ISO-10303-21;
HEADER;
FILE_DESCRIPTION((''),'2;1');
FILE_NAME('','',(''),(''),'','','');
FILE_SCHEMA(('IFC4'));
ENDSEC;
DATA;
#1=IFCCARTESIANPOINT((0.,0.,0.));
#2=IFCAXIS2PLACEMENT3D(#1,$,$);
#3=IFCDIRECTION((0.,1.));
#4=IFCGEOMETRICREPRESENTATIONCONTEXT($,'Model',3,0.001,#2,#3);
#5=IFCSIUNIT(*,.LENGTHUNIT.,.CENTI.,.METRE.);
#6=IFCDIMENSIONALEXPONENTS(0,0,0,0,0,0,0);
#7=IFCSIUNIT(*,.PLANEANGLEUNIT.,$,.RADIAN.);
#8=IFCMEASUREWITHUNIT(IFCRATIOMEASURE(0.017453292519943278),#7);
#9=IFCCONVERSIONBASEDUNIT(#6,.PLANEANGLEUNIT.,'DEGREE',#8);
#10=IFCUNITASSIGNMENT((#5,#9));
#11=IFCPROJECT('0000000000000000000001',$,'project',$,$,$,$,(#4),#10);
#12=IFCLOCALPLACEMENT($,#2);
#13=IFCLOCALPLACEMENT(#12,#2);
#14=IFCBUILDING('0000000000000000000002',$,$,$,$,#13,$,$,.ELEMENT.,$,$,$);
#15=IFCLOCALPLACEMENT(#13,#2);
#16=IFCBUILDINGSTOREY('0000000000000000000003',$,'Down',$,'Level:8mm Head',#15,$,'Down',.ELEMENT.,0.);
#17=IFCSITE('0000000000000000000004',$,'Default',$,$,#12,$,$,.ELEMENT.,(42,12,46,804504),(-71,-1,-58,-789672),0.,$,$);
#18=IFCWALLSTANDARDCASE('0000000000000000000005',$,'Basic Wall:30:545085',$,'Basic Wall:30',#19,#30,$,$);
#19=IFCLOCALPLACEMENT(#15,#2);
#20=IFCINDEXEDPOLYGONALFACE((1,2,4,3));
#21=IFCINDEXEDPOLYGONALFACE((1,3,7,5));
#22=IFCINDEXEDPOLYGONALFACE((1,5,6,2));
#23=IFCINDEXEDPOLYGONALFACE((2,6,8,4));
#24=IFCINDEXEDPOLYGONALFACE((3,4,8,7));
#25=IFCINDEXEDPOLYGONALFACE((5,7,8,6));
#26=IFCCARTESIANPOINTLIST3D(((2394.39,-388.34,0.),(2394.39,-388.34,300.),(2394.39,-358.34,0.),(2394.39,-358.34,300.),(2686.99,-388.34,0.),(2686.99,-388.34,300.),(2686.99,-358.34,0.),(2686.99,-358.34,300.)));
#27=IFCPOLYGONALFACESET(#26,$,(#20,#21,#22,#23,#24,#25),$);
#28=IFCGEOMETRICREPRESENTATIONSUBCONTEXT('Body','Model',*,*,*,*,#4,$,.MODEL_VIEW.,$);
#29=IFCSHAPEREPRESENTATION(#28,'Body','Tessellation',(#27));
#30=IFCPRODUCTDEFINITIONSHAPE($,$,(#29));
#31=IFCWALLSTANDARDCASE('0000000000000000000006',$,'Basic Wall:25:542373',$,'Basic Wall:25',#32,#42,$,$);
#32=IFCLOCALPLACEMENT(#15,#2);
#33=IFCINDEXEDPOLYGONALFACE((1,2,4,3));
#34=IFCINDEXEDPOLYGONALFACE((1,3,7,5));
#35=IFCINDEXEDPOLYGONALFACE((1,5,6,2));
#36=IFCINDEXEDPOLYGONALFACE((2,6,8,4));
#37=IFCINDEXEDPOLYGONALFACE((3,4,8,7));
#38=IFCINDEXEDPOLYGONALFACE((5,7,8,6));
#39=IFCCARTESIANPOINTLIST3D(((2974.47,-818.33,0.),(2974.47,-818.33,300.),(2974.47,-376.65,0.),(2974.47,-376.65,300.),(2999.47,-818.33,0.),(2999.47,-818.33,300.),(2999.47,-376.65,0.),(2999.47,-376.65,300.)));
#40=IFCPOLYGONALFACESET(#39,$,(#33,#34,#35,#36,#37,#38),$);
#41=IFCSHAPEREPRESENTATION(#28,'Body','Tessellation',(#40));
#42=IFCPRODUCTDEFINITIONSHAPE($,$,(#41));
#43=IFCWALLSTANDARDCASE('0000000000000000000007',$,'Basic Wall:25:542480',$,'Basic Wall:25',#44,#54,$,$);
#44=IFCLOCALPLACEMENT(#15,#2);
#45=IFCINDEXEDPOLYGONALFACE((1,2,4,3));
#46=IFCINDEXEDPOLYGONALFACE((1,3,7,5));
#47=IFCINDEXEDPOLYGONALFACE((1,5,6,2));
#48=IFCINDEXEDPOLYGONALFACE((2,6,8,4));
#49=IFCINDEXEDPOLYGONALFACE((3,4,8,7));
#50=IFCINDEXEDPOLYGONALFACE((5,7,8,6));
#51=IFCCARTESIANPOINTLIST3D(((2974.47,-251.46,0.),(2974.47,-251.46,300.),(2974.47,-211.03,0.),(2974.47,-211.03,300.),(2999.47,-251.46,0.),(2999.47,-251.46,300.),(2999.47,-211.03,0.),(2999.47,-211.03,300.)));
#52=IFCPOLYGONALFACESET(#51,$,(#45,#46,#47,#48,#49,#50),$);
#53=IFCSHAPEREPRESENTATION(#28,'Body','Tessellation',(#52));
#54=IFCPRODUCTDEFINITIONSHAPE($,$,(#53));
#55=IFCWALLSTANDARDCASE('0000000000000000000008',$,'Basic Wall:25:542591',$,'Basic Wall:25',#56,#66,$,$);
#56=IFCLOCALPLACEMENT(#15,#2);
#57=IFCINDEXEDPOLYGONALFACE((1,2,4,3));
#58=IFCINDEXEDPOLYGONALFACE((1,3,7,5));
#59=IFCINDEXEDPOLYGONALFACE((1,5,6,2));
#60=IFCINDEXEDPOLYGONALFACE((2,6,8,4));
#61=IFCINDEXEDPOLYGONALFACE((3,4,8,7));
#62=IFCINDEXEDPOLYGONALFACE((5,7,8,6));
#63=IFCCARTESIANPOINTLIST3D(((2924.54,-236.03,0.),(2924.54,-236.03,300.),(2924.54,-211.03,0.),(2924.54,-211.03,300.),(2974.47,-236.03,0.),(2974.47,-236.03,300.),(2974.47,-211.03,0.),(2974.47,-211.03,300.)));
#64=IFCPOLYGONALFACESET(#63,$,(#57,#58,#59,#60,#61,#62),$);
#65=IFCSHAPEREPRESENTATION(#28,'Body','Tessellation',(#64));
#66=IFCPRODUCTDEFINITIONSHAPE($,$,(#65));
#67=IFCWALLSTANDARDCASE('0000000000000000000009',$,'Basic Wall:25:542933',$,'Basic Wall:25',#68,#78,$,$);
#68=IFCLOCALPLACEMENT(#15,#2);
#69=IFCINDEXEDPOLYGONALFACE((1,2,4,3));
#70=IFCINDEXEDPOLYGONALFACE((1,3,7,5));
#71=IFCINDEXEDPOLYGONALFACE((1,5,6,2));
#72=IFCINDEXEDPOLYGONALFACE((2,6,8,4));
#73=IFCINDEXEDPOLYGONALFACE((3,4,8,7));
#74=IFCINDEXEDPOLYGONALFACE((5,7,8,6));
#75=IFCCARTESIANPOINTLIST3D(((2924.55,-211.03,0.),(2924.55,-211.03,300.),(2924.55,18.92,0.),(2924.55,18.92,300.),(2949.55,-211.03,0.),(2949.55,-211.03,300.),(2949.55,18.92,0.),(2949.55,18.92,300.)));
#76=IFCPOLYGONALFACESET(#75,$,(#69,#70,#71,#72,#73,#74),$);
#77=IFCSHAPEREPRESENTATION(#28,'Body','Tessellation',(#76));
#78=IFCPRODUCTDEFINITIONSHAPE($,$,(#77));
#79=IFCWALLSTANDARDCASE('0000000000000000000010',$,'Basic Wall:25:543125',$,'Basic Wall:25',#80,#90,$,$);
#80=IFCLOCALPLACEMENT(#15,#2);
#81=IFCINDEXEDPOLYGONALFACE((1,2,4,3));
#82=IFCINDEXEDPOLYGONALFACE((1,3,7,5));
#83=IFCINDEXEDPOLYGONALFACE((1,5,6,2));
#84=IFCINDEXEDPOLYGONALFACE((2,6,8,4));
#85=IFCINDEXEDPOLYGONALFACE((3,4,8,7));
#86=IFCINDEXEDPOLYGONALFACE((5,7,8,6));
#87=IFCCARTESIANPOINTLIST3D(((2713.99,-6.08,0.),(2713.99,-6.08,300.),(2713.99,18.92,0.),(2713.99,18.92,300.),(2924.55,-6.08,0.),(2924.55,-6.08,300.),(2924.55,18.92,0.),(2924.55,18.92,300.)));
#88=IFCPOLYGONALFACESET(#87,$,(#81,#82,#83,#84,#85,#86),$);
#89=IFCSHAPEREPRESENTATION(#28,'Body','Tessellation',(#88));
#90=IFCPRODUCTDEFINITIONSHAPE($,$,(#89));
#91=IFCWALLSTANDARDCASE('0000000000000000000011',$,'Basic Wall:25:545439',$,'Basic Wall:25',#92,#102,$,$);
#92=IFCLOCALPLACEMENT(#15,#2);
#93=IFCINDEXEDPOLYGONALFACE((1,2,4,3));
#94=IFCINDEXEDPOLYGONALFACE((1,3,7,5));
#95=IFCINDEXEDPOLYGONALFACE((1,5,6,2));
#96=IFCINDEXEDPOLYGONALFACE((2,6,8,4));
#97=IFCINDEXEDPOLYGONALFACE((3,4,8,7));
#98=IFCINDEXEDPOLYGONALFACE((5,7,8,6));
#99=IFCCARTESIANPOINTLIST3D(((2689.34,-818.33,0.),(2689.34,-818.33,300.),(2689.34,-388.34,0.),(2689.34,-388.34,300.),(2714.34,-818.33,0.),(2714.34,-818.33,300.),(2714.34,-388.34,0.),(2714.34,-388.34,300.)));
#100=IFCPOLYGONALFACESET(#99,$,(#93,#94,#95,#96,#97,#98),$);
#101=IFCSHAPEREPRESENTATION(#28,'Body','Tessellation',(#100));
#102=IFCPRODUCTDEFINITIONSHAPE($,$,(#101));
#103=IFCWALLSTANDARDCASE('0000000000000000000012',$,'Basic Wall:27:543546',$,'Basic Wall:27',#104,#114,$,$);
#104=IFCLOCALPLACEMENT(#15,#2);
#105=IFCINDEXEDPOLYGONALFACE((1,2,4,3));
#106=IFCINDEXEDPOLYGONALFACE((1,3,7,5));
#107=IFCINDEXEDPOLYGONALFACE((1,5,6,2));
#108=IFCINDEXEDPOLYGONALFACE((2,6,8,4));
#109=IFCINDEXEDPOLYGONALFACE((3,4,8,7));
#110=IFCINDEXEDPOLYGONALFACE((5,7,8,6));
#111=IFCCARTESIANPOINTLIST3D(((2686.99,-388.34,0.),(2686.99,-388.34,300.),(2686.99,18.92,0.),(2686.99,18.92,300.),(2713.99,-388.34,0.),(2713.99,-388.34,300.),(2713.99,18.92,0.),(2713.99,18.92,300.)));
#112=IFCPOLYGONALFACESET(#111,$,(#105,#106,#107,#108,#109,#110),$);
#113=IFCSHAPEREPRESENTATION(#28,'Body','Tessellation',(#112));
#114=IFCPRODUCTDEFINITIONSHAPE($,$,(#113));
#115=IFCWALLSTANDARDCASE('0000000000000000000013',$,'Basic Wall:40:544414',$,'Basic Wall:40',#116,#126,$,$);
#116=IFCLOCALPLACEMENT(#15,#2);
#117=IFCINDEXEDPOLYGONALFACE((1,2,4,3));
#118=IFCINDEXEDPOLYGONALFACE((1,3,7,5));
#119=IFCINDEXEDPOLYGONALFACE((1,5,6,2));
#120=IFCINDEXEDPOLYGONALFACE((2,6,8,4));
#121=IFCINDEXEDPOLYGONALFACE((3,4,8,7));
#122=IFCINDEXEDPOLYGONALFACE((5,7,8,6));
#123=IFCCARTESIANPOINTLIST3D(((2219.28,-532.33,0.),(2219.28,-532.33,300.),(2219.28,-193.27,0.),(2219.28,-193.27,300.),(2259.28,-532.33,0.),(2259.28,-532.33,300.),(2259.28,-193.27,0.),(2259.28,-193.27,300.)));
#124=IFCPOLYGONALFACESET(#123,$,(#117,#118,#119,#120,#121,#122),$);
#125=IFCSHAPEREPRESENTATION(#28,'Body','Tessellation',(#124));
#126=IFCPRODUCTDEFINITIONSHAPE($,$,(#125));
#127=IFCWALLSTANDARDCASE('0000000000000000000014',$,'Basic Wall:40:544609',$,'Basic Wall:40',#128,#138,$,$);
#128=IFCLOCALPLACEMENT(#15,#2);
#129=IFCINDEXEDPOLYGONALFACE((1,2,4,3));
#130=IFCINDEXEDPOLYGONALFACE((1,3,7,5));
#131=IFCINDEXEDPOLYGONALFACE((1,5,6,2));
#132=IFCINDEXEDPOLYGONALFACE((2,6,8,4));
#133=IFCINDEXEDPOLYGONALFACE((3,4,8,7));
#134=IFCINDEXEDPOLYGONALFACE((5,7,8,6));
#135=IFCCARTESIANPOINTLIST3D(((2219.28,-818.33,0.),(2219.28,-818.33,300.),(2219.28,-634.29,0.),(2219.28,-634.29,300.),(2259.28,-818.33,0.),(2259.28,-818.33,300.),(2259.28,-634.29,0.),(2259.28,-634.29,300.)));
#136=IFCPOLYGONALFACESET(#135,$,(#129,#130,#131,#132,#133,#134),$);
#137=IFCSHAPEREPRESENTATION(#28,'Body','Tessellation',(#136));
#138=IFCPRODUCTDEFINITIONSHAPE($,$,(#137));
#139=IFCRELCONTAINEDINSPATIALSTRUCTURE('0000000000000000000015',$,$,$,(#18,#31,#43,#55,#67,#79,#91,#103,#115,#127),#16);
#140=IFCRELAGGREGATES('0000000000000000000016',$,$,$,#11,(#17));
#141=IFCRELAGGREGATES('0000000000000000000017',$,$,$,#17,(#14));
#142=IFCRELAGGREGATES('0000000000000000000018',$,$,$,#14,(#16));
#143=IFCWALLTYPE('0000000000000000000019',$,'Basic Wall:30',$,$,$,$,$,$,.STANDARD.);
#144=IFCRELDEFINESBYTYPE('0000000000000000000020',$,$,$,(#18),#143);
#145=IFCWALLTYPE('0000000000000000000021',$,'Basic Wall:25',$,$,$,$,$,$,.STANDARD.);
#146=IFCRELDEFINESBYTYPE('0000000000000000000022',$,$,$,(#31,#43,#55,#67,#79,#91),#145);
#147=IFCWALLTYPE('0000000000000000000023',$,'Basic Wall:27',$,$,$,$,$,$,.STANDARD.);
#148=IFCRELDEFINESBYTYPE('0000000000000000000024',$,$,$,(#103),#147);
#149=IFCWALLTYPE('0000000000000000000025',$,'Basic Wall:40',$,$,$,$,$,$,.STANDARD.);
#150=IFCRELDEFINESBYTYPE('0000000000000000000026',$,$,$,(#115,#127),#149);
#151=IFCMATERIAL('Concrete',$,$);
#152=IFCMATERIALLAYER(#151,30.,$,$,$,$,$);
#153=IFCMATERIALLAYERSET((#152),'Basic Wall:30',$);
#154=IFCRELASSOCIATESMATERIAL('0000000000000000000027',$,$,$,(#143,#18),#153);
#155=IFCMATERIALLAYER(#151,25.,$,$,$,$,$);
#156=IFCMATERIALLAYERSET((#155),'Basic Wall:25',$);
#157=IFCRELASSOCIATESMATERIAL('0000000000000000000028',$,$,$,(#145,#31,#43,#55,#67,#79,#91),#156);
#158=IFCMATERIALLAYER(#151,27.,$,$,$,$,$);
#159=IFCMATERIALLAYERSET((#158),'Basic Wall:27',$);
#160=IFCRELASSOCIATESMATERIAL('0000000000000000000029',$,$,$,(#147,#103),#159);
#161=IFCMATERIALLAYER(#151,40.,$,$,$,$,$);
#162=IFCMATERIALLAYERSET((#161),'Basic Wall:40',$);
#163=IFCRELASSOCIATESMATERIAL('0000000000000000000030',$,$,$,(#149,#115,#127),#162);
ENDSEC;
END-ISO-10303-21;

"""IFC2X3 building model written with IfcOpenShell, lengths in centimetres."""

from ifc_helpers import new_model, entity, si_unit, converted_unit, direction, frame, frame_2d, origin, place, context, subcontext, project, spatial, rectangle, extrude, material, layer, layer_set, layer_usage, type_object, element, save


model = new_model("IFC2X3")

# Units and contexts
model_context = context("Model", 3, precision=0.001, world=origin(), true_north=direction((0.0, 1.0)))
body_context = subcontext(model_context, "Body", "Model", "MODEL_VIEW")
ifc_project = project(units=[si_unit("LENGTHUNIT", "METRE", prefix="CENTI"), converted_unit("PLANEANGLEUNIT", "DEGREE", entity("IfcRatioMeasure", 0.017453292519943278), si_unit("PLANEANGLEUNIT", "RADIAN"), dimensions=[0, 0, 0, 0, 0, 0, 0])], contexts=[model_context])

# Site, building, storey
site_placement = place(None, origin())
site = spatial("IfcSite", under=ifc_project, at=site_placement, Name="Default", CompositionType="ELEMENT", RefLatitude=(42, 12, 46, 804504), RefLongitude=(-71, -1, -58, -789672), RefElevation=0.0)
building_placement = place(site_placement, origin())
building = spatial("IfcBuilding", under=site, at=building_placement, CompositionType="ELEMENT")
storey_placement = place(building_placement, origin())
storey = spatial("IfcBuildingStorey", under=building, at=storey_placement, Name="Down", ObjectType="Level:8mm Head", LongName="Down", CompositionType="ELEMENT", Elevation=0.0)

# Shared definitions
ifc_material = material(Name="Concrete")

# Walls
ifc_layer_1 = layer(ifc_material, 30.0)
ifc_layer_set_1 = layer_set([ifc_layer_1], Name="Basic Wall:30")
wall_type_1 = type_object("IfcWallType", Name="Basic Wall:30", PredefinedType="STANDARD", material=ifc_layer_set_1)
ifc_layer_usage_1 = layer_usage(ifc_layer_set_1, "AXIS2", "NEGATIVE", 15.0)
wall_1_placement = place(storey_placement, frame((2394.39, -373.34, 0.0)))
element("IfcWallStandardCase", 1, at=wall_1_placement, inside=storey, type_object=wall_type_1, material=ifc_layer_usage_1, Name="Basic Wall:30:545085", ObjectType="Basic Wall:30", context=body_context, shape_type="SweptSolid", body=[
    extrude(rectangle(XDim=292.6, YDim=30.0, at=frame_2d((146.3, 0.0), x_axis=(-1.0, 0.0))), origin(), (0.0, 0.0, 1.0), 300.0),
])
ifc_layer_2 = layer(ifc_material, 25.0)
ifc_layer_set_2 = layer_set([ifc_layer_2], Name="Basic Wall:25")
ifc_layer_usage_2 = layer_usage(ifc_layer_set_2, "AXIS2", "POSITIVE", -12.5)
wall_type_2 = type_object("IfcWallType", Name="Basic Wall:25", PredefinedType="STANDARD", material=ifc_layer_set_2)
wall_2_placement = place(storey_placement, frame((2986.97, -818.33, 0.0), z_axis=(0.0, 0.0, 1.0), x_axis=(0.0, 1.0, 0.0)))
element("IfcWallStandardCase", 2, at=wall_2_placement, inside=storey, type_object=wall_type_2, material=ifc_layer_usage_2, Name="Basic Wall:25:542373", ObjectType="Basic Wall:25", context=body_context, shape_type="SweptSolid", body=[
    extrude(rectangle(XDim=441.68, YDim=25.0, at=frame_2d((220.84, 0.0), x_axis=(-1.0, 0.0))), origin(), (0.0, 0.0, 1.0), 300.0),
])
ifc_layer_usage_3 = layer_usage(ifc_layer_set_2, "AXIS2", "POSITIVE", -12.5)
wall_3_placement = place(storey_placement, frame((2986.97, -251.46, 0.0), z_axis=(0.0, 0.0, 1.0), x_axis=(0.0, 1.0, 0.0)))
element("IfcWallStandardCase", 3, at=wall_3_placement, inside=storey, type_object=wall_type_2, material=ifc_layer_usage_3, Name="Basic Wall:25:542480", ObjectType="Basic Wall:25", context=body_context, shape_type="SweptSolid", body=[
    extrude(rectangle(XDim=40.43, YDim=25.0, at=frame_2d((20.21, 0.0), x_axis=(-1.0, 0.0))), origin(), (0.0, 0.0, 1.0), 300.0),
])
ifc_layer_usage_4 = layer_usage(ifc_layer_set_2, "AXIS2", "POSITIVE", -12.5)
wall_4_placement = place(storey_placement, frame((2974.47, -223.53, 0.0), z_axis=(0.0, 0.0, 1.0), x_axis=(-1.0, 0.0, 0.0)))
element("IfcWallStandardCase", 4, at=wall_4_placement, inside=storey, type_object=wall_type_2, material=ifc_layer_usage_4, Name="Basic Wall:25:542591", ObjectType="Basic Wall:25", context=body_context, shape_type="SweptSolid", body=[
    extrude(rectangle(XDim=49.94, YDim=25.0, at=frame_2d((24.97, 0.0), x_axis=(-1.0, 0.0))), origin(), (0.0, 0.0, 1.0), 300.0),
])
ifc_layer_usage_5 = layer_usage(ifc_layer_set_2, "AXIS2", "POSITIVE", -12.5)
wall_5_placement = place(storey_placement, frame((2937.05, -211.03, 0.0), z_axis=(0.0, 0.0, 1.0), x_axis=(0.0, 1.0, 0.0)))
element("IfcWallStandardCase", 5, at=wall_5_placement, inside=storey, type_object=wall_type_2, material=ifc_layer_usage_5, Name="Basic Wall:25:542933", ObjectType="Basic Wall:25", context=body_context, shape_type="SweptSolid", body=[
    extrude(rectangle(XDim=229.95, YDim=25.0, at=frame_2d((114.97, 0.0), x_axis=(-1.0, 0.0))), origin(), (0.0, 0.0, 1.0), 300.0),
])
ifc_layer_usage_6 = layer_usage(ifc_layer_set_2, "AXIS2", "POSITIVE", -12.5)
wall_6_placement = place(storey_placement, frame((2924.55, 6.42, 0.0), z_axis=(0.0, 0.0, 1.0), x_axis=(-1.0, 0.0, 0.0)))
element("IfcWallStandardCase", 6, at=wall_6_placement, inside=storey, type_object=wall_type_2, material=ifc_layer_usage_6, Name="Basic Wall:25:543125", ObjectType="Basic Wall:25", context=body_context, shape_type="SweptSolid", body=[
    extrude(rectangle(XDim=210.56, YDim=25.0, at=frame_2d((105.28, 0.0), x_axis=(-1.0, 0.0))), origin(), (0.0, 0.0, 1.0), 300.0),
])
ifc_layer_usage_7 = layer_usage(ifc_layer_set_2, "AXIS2", "POSITIVE", -12.5)
wall_7_placement = place(storey_placement, frame((2701.84, -388.34, 0.0), z_axis=(0.0, 0.0, 1.0), x_axis=(0.0, -1.0, 0.0)))
element("IfcWallStandardCase", 7, at=wall_7_placement, inside=storey, type_object=wall_type_2, material=ifc_layer_usage_7, Name="Basic Wall:25:545439", ObjectType="Basic Wall:25", context=body_context, shape_type="SweptSolid", body=[
    extrude(rectangle(XDim=430.0, YDim=25.0, at=frame_2d((215.0, 0.0), x_axis=(-1.0, 0.0))), origin(), (0.0, 0.0, 1.0), 300.0),
])
ifc_layer_3 = layer(ifc_material, 27.0)
ifc_layer_set_3 = layer_set([ifc_layer_3], Name="Basic Wall:27")
ifc_layer_usage_8 = layer_usage(ifc_layer_set_3, "AXIS2", "POSITIVE", -13.5)
wall_type_3 = type_object("IfcWallType", Name="Basic Wall:27", PredefinedType="STANDARD", material=ifc_layer_set_3)
wall_8_placement = place(storey_placement, frame((2700.49, 18.92, 0.0), z_axis=(0.0, 0.0, 1.0), x_axis=(0.0, -1.0, 0.0)))
element("IfcWallStandardCase", 8, at=wall_8_placement, inside=storey, type_object=wall_type_3, material=ifc_layer_usage_8, Name="Basic Wall:27:543546", ObjectType="Basic Wall:27", context=body_context, shape_type="SweptSolid", body=[
    extrude(rectangle(XDim=407.25, YDim=27.0, at=frame_2d((203.63, 0.0), x_axis=(-1.0, 0.0))), origin(), (0.0, 0.0, 1.0), 300.0),
])
ifc_layer_4 = layer(ifc_material, 40.0)
ifc_layer_set_4 = layer_set([ifc_layer_4], Name="Basic Wall:40")
ifc_layer_usage_9 = layer_usage(ifc_layer_set_4, "AXIS2", "POSITIVE", -20.0)
wall_type_4 = type_object("IfcWallType", Name="Basic Wall:40", PredefinedType="STANDARD", material=ifc_layer_set_4)
wall_9_placement = place(storey_placement, frame((2239.28, -193.27, 0.0), z_axis=(0.0, 0.0, 1.0), x_axis=(0.0, -1.0, 0.0)))
element("IfcWallStandardCase", 9, at=wall_9_placement, inside=storey, type_object=wall_type_4, material=ifc_layer_usage_9, Name="Basic Wall:40:544414", ObjectType="Basic Wall:40", context=body_context, shape_type="SweptSolid", body=[
    extrude(rectangle(XDim=339.06, YDim=40.0, at=frame_2d((169.53, 0.0), x_axis=(-1.0, 0.0))), origin(), (0.0, 0.0, 1.0), 300.0),
])
ifc_layer_usage_10 = layer_usage(ifc_layer_set_4, "AXIS2", "POSITIVE", -20.0)
wall_10_placement = place(storey_placement, frame((2239.28, -634.29, 0.0), z_axis=(0.0, 0.0, 1.0), x_axis=(0.0, -1.0, 0.0)))
element("IfcWallStandardCase", 10, at=wall_10_placement, inside=storey, type_object=wall_type_4, material=ifc_layer_usage_10, Name="Basic Wall:40:544609", ObjectType="Basic Wall:40", context=body_context, shape_type="SweptSolid", body=[
    extrude(rectangle(XDim=184.04, YDim=40.0, at=frame_2d((92.02, 0.0), x_axis=(-1.0, 0.0))), origin(), (0.0, 0.0, 1.0), 300.0),
])

save(model, "model.ifc")
